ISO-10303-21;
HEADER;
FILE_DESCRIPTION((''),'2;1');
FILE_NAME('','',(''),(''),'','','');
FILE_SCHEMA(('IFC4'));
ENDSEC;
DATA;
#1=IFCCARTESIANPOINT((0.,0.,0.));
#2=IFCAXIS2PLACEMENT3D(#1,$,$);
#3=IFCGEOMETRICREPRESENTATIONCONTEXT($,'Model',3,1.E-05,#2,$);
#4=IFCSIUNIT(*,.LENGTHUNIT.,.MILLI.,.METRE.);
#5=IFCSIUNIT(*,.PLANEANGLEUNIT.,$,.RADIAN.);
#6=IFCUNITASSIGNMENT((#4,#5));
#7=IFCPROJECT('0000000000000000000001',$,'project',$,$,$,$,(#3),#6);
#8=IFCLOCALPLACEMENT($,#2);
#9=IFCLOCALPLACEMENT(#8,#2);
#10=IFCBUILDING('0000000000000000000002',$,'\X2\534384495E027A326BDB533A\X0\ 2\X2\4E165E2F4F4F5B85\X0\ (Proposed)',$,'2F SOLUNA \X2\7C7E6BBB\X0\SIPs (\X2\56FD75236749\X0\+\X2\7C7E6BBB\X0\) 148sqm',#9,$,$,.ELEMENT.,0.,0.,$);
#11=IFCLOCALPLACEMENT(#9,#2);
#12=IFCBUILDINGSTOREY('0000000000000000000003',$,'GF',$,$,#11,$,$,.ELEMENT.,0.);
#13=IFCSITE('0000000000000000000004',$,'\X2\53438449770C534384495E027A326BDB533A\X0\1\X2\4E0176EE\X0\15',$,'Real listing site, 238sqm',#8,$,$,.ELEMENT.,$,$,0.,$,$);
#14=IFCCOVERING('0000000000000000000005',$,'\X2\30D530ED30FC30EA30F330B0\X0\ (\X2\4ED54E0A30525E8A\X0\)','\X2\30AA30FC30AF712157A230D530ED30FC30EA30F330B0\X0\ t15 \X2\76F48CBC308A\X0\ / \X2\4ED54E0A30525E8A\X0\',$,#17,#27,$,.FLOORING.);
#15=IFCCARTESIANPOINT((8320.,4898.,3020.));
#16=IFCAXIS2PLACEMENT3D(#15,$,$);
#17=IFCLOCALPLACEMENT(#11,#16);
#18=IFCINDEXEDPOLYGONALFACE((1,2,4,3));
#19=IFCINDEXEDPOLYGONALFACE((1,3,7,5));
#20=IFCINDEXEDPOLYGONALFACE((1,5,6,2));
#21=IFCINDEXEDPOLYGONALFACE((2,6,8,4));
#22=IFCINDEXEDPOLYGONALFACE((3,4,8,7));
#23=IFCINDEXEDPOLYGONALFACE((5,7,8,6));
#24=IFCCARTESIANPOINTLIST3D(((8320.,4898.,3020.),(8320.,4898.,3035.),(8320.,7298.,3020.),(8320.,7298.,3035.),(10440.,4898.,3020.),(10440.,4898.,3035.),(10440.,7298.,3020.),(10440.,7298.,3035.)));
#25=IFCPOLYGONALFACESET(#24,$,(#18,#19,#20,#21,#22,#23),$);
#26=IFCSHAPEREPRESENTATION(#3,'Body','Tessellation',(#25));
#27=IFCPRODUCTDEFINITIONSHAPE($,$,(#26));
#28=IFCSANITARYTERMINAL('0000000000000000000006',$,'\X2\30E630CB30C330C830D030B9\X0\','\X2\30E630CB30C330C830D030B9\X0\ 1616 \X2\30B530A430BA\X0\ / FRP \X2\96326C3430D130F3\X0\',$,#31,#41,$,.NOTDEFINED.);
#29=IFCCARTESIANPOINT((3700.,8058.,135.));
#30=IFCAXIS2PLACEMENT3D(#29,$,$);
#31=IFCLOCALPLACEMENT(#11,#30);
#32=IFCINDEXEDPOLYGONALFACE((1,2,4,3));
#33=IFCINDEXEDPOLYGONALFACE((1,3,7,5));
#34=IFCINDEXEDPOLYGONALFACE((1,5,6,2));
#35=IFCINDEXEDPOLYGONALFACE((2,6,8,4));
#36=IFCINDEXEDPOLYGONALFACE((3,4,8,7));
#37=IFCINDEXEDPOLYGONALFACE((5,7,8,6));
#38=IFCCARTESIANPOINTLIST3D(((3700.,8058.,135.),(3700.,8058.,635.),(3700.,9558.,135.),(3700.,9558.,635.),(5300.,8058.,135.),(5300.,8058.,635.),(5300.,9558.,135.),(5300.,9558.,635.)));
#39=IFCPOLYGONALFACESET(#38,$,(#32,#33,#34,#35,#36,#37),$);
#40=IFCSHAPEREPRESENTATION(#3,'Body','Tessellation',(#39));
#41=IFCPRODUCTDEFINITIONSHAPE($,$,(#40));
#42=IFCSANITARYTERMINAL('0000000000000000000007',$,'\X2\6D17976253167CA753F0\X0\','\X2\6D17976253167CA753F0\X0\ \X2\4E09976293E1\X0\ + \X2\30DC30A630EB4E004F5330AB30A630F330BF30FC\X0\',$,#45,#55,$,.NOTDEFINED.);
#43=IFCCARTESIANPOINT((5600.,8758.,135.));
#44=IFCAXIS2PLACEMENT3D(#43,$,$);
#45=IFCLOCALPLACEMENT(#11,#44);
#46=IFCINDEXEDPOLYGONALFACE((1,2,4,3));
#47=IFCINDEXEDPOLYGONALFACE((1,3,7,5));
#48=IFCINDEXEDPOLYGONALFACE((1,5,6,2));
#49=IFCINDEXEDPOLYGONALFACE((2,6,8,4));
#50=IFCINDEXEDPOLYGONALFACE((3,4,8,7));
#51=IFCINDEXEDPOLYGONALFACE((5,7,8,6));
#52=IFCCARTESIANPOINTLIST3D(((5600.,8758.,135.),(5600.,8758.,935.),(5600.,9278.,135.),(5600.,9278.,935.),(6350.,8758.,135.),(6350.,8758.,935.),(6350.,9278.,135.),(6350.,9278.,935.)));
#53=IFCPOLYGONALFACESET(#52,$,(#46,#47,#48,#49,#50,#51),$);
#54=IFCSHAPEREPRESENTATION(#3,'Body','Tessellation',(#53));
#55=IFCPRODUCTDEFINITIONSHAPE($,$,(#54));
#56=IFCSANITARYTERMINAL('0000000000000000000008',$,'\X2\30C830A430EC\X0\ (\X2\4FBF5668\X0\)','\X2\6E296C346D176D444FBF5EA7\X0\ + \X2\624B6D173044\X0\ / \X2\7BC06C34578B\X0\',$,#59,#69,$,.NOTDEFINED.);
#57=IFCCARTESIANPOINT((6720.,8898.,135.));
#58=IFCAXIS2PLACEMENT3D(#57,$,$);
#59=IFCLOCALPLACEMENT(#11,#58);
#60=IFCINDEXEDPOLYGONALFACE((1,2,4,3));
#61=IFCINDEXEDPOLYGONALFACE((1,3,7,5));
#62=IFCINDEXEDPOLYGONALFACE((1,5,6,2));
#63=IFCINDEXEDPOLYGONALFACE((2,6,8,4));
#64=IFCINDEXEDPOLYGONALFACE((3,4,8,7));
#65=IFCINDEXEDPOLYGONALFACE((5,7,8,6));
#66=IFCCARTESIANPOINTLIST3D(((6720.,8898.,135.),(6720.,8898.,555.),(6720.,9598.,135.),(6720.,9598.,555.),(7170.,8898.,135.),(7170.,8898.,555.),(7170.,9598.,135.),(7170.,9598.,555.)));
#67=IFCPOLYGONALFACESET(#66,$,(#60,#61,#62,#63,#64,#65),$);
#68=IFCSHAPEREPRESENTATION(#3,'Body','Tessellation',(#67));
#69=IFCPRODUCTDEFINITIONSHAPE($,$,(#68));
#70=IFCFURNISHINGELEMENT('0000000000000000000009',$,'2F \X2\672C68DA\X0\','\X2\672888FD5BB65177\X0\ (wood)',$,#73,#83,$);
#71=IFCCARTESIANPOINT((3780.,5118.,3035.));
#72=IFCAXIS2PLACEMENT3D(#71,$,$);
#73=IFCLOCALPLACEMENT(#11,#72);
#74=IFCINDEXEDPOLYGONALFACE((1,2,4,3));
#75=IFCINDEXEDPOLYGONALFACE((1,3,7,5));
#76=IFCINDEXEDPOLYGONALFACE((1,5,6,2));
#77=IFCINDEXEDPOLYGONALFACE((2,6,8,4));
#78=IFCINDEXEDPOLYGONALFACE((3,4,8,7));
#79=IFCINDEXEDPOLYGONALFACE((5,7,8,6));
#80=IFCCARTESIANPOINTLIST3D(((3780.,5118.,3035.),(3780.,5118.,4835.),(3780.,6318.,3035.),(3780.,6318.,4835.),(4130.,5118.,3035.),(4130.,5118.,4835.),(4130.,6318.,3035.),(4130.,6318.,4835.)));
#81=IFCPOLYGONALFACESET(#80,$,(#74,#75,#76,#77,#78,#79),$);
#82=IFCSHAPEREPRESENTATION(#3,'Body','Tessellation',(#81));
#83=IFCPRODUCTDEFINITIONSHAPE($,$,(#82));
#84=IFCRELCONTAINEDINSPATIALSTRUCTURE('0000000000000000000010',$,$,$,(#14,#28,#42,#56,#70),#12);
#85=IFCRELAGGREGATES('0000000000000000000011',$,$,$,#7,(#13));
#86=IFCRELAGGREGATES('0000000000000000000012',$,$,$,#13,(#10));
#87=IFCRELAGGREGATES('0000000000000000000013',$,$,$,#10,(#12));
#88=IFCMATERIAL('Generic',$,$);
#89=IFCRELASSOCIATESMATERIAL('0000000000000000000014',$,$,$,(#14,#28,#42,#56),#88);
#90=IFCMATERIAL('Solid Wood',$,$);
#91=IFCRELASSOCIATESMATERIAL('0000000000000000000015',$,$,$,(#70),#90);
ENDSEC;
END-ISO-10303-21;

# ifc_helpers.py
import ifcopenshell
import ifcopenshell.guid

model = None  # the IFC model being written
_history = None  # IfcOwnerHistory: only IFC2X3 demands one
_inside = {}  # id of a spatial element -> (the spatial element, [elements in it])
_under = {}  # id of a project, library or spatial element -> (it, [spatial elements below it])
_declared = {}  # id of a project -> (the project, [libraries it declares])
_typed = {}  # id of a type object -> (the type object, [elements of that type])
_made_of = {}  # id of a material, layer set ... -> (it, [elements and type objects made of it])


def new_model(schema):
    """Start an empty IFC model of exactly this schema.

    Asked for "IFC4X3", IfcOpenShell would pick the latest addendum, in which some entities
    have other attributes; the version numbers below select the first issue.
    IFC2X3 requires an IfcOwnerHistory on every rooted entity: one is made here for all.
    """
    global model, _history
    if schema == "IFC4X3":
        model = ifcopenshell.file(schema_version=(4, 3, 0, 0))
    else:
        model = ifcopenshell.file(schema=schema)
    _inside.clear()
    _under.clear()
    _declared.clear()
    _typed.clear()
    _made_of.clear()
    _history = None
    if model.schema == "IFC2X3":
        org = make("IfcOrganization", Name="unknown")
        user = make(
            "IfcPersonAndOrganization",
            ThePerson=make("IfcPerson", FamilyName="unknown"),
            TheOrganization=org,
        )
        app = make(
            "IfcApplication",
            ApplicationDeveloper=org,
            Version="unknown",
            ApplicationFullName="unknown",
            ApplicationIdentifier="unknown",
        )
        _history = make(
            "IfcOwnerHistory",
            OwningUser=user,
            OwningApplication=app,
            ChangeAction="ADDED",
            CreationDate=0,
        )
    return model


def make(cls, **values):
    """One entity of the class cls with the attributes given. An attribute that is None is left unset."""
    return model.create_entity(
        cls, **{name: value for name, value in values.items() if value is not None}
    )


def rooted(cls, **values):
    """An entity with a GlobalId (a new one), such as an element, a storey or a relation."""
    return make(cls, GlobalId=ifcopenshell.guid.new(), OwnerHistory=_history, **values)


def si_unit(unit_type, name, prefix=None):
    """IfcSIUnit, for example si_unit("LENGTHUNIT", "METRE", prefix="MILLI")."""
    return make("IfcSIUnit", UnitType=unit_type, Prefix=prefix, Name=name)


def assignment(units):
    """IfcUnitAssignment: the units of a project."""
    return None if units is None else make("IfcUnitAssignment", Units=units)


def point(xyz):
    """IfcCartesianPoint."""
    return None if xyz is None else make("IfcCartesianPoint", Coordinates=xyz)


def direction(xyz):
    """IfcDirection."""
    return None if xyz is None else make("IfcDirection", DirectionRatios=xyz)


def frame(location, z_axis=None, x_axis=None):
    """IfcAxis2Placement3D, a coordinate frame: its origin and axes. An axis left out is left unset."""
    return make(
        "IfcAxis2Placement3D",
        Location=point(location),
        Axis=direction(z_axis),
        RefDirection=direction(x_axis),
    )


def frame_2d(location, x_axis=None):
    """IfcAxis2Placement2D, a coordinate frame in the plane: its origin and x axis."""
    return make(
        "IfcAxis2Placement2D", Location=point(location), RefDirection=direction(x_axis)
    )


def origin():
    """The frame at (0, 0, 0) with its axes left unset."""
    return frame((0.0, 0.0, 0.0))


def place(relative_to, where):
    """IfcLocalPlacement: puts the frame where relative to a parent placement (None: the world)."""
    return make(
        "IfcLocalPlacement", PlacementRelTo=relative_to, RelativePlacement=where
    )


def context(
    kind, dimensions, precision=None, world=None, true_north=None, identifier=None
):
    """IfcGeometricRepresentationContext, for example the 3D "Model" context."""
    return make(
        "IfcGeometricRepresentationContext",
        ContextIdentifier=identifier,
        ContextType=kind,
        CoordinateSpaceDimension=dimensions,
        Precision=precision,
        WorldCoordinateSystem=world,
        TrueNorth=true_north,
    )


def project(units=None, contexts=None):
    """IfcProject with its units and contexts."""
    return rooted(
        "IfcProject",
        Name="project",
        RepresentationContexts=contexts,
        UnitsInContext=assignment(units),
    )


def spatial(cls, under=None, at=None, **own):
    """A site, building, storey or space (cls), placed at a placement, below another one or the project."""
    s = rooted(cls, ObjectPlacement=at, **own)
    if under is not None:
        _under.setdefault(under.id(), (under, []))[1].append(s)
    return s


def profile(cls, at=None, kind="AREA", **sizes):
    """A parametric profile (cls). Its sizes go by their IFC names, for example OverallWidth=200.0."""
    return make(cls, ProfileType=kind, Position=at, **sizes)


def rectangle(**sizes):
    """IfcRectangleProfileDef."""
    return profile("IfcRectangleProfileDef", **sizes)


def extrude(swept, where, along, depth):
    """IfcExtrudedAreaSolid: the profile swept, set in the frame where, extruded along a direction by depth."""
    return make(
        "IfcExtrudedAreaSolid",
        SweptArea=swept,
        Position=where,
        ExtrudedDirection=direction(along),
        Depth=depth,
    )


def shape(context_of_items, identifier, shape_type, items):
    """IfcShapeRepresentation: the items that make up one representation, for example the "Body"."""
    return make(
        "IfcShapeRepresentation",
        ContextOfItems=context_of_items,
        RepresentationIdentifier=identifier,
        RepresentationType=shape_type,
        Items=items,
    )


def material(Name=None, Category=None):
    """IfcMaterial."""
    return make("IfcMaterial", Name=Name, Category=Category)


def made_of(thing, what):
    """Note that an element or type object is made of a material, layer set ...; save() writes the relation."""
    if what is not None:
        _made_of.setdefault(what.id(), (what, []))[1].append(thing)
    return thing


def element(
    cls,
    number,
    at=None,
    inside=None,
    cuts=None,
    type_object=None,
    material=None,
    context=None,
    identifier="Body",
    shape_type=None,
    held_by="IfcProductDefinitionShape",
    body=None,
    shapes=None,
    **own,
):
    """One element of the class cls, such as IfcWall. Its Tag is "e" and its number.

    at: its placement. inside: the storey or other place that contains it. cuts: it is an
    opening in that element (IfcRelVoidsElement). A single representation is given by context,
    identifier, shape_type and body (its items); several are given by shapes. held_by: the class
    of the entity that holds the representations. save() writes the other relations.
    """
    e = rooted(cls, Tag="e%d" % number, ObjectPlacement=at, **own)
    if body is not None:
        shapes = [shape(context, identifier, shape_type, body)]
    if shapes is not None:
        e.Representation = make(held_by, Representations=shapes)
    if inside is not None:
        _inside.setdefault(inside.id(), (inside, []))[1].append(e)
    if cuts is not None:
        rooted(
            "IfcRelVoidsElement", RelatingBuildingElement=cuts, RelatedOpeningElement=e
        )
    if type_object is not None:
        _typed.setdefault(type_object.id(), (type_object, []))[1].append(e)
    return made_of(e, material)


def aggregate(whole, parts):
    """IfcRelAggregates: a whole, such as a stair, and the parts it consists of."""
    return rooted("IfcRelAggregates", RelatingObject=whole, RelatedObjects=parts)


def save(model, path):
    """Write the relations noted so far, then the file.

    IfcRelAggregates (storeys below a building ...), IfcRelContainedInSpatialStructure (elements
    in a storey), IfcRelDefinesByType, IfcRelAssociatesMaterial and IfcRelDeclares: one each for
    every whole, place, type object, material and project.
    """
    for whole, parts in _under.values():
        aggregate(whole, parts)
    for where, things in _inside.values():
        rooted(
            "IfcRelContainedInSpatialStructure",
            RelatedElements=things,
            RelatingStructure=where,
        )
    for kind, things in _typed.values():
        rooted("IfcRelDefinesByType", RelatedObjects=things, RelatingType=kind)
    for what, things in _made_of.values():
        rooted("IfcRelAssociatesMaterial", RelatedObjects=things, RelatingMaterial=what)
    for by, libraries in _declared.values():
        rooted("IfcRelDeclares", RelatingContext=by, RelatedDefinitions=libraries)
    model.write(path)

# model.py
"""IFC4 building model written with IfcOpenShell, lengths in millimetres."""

from ifc_helpers import new_model, si_unit, frame, frame_2d, origin, place, context, project, spatial, rectangle, extrude, material, element, save


model = new_model("IFC4")

# Units and contexts
model_context = context("Model", 3, precision=1e-05, world=origin())
ifc_project = project(units=[si_unit("LENGTHUNIT", "METRE", prefix="MILLI"), si_unit("PLANEANGLEUNIT", "RADIAN")], contexts=[model_context])

# Site, building, storey
site_placement = place(None, origin())
site = spatial("IfcSite", under=ifc_project, at=site_placement, Name="千葉県千葉市稲毛区1丁目15", ObjectType="Real listing site, 238sqm", CompositionType="ELEMENT", RefElevation=0.0)
building_placement = place(site_placement, origin())
building = spatial("IfcBuilding", under=site, at=building_placement, Name="千葉市稲毛区 2世帯住宅 (Proposed)", ObjectType="2F SOLUNA 籾殻SIPs (国産杉+籾殻) 148sqm", CompositionType="ELEMENT", ElevationOfRefHeight=0.0, ElevationOfTerrain=0.0)
storey_placement = place(building_placement, origin())
storey = spatial("IfcBuildingStorey", under=building, at=storey_placement, Name="GF", CompositionType="ELEMENT", Elevation=0.0)

# Shared definitions
ifc_material_1 = material(Name="Solid Wood")
ifc_material_2 = material(Name="Generic")

# Covering
covering_1_placement = place(storey_placement, frame((8320.0, 4898.0, 3020.0)))
element("IfcCovering", 1, at=covering_1_placement, inside=storey, material=ifc_material_2, Name="フローリング (仕上げ床)", Description="オーク無垢フローリング t15 直貼り / 仕上げ床", PredefinedType="FLOORING", context=model_context, shape_type="SweptSolid", body=[
    extrude(rectangle(XDim=2120.0, YDim=2400.0, at=frame_2d((1060.0, 1200.0))), frame((8320.0, 4898.0, 3020.0)), (0.0, 0.0, 1.0), 15.0),
])

# Sanitary terminals
sanitary_terminal_1_placement = place(storey_placement, frame((3700.0, 8058.0, 135.0)))
element("IfcSanitaryTerminal", 2, at=sanitary_terminal_1_placement, inside=storey, material=ifc_material_2, Name="ユニットバス", Description="ユニットバス 1616 サイズ / FRP 防水パン", PredefinedType="NOTDEFINED", context=model_context, shape_type="SweptSolid", body=[
    extrude(rectangle(XDim=1600.0, YDim=1500.0, at=frame_2d((800.0, 750.0))), frame((3700.0, 8058.0, 135.0)), (0.0, 0.0, 1.0), 500.0),
])
sanitary_terminal_2_placement = place(storey_placement, frame((5600.0, 8758.0, 135.0)))
element("IfcSanitaryTerminal", 3, at=sanitary_terminal_2_placement, inside=storey, material=ifc_material_2, Name="洗面化粧台", Description="洗面化粧台 三面鏡 + ボウル一体カウンター", PredefinedType="NOTDEFINED", context=model_context, shape_type="SweptSolid", body=[
    extrude(rectangle(XDim=750.0, YDim=520.0, at=frame_2d((375.0, 260.0))), frame((5600.0, 8758.0, 135.0)), (0.0, 0.0, 1.0), 800.0),
])
sanitary_terminal_3_placement = place(storey_placement, frame((6720.0, 8898.0, 135.0)))
element("IfcSanitaryTerminal", 4, at=sanitary_terminal_3_placement, inside=storey, material=ifc_material_2, Name="トイレ (便器)", Description="温水洗浄便座 + 手洗い / 節水型", PredefinedType="NOTDEFINED", context=model_context, shape_type="SweptSolid", body=[
    extrude(rectangle(XDim=450.0, YDim=700.0, at=frame_2d((225.0, 350.0))), frame((6720.0, 8898.0, 135.0)), (0.0, 0.0, 1.0), 420.0),
])

# Furnishing element
furnishing_placement = place(storey_placement, frame((3780.0, 5118.0, 3035.0)))
element("IfcFurnishingElement", 5, at=furnishing_placement, inside=storey, material=ifc_material_1, Name="2F 本棚", Description="木製家具 (wood)", context=model_context, shape_type="SweptSolid", body=[
    extrude(rectangle(XDim=350.0, YDim=1200.0, at=frame_2d((175.0, 600.0))), frame((3780.0, 5118.0, 3035.0)), (0.0, 0.0, 1.0), 1800.0),
])

save(model, "model.ifc")
